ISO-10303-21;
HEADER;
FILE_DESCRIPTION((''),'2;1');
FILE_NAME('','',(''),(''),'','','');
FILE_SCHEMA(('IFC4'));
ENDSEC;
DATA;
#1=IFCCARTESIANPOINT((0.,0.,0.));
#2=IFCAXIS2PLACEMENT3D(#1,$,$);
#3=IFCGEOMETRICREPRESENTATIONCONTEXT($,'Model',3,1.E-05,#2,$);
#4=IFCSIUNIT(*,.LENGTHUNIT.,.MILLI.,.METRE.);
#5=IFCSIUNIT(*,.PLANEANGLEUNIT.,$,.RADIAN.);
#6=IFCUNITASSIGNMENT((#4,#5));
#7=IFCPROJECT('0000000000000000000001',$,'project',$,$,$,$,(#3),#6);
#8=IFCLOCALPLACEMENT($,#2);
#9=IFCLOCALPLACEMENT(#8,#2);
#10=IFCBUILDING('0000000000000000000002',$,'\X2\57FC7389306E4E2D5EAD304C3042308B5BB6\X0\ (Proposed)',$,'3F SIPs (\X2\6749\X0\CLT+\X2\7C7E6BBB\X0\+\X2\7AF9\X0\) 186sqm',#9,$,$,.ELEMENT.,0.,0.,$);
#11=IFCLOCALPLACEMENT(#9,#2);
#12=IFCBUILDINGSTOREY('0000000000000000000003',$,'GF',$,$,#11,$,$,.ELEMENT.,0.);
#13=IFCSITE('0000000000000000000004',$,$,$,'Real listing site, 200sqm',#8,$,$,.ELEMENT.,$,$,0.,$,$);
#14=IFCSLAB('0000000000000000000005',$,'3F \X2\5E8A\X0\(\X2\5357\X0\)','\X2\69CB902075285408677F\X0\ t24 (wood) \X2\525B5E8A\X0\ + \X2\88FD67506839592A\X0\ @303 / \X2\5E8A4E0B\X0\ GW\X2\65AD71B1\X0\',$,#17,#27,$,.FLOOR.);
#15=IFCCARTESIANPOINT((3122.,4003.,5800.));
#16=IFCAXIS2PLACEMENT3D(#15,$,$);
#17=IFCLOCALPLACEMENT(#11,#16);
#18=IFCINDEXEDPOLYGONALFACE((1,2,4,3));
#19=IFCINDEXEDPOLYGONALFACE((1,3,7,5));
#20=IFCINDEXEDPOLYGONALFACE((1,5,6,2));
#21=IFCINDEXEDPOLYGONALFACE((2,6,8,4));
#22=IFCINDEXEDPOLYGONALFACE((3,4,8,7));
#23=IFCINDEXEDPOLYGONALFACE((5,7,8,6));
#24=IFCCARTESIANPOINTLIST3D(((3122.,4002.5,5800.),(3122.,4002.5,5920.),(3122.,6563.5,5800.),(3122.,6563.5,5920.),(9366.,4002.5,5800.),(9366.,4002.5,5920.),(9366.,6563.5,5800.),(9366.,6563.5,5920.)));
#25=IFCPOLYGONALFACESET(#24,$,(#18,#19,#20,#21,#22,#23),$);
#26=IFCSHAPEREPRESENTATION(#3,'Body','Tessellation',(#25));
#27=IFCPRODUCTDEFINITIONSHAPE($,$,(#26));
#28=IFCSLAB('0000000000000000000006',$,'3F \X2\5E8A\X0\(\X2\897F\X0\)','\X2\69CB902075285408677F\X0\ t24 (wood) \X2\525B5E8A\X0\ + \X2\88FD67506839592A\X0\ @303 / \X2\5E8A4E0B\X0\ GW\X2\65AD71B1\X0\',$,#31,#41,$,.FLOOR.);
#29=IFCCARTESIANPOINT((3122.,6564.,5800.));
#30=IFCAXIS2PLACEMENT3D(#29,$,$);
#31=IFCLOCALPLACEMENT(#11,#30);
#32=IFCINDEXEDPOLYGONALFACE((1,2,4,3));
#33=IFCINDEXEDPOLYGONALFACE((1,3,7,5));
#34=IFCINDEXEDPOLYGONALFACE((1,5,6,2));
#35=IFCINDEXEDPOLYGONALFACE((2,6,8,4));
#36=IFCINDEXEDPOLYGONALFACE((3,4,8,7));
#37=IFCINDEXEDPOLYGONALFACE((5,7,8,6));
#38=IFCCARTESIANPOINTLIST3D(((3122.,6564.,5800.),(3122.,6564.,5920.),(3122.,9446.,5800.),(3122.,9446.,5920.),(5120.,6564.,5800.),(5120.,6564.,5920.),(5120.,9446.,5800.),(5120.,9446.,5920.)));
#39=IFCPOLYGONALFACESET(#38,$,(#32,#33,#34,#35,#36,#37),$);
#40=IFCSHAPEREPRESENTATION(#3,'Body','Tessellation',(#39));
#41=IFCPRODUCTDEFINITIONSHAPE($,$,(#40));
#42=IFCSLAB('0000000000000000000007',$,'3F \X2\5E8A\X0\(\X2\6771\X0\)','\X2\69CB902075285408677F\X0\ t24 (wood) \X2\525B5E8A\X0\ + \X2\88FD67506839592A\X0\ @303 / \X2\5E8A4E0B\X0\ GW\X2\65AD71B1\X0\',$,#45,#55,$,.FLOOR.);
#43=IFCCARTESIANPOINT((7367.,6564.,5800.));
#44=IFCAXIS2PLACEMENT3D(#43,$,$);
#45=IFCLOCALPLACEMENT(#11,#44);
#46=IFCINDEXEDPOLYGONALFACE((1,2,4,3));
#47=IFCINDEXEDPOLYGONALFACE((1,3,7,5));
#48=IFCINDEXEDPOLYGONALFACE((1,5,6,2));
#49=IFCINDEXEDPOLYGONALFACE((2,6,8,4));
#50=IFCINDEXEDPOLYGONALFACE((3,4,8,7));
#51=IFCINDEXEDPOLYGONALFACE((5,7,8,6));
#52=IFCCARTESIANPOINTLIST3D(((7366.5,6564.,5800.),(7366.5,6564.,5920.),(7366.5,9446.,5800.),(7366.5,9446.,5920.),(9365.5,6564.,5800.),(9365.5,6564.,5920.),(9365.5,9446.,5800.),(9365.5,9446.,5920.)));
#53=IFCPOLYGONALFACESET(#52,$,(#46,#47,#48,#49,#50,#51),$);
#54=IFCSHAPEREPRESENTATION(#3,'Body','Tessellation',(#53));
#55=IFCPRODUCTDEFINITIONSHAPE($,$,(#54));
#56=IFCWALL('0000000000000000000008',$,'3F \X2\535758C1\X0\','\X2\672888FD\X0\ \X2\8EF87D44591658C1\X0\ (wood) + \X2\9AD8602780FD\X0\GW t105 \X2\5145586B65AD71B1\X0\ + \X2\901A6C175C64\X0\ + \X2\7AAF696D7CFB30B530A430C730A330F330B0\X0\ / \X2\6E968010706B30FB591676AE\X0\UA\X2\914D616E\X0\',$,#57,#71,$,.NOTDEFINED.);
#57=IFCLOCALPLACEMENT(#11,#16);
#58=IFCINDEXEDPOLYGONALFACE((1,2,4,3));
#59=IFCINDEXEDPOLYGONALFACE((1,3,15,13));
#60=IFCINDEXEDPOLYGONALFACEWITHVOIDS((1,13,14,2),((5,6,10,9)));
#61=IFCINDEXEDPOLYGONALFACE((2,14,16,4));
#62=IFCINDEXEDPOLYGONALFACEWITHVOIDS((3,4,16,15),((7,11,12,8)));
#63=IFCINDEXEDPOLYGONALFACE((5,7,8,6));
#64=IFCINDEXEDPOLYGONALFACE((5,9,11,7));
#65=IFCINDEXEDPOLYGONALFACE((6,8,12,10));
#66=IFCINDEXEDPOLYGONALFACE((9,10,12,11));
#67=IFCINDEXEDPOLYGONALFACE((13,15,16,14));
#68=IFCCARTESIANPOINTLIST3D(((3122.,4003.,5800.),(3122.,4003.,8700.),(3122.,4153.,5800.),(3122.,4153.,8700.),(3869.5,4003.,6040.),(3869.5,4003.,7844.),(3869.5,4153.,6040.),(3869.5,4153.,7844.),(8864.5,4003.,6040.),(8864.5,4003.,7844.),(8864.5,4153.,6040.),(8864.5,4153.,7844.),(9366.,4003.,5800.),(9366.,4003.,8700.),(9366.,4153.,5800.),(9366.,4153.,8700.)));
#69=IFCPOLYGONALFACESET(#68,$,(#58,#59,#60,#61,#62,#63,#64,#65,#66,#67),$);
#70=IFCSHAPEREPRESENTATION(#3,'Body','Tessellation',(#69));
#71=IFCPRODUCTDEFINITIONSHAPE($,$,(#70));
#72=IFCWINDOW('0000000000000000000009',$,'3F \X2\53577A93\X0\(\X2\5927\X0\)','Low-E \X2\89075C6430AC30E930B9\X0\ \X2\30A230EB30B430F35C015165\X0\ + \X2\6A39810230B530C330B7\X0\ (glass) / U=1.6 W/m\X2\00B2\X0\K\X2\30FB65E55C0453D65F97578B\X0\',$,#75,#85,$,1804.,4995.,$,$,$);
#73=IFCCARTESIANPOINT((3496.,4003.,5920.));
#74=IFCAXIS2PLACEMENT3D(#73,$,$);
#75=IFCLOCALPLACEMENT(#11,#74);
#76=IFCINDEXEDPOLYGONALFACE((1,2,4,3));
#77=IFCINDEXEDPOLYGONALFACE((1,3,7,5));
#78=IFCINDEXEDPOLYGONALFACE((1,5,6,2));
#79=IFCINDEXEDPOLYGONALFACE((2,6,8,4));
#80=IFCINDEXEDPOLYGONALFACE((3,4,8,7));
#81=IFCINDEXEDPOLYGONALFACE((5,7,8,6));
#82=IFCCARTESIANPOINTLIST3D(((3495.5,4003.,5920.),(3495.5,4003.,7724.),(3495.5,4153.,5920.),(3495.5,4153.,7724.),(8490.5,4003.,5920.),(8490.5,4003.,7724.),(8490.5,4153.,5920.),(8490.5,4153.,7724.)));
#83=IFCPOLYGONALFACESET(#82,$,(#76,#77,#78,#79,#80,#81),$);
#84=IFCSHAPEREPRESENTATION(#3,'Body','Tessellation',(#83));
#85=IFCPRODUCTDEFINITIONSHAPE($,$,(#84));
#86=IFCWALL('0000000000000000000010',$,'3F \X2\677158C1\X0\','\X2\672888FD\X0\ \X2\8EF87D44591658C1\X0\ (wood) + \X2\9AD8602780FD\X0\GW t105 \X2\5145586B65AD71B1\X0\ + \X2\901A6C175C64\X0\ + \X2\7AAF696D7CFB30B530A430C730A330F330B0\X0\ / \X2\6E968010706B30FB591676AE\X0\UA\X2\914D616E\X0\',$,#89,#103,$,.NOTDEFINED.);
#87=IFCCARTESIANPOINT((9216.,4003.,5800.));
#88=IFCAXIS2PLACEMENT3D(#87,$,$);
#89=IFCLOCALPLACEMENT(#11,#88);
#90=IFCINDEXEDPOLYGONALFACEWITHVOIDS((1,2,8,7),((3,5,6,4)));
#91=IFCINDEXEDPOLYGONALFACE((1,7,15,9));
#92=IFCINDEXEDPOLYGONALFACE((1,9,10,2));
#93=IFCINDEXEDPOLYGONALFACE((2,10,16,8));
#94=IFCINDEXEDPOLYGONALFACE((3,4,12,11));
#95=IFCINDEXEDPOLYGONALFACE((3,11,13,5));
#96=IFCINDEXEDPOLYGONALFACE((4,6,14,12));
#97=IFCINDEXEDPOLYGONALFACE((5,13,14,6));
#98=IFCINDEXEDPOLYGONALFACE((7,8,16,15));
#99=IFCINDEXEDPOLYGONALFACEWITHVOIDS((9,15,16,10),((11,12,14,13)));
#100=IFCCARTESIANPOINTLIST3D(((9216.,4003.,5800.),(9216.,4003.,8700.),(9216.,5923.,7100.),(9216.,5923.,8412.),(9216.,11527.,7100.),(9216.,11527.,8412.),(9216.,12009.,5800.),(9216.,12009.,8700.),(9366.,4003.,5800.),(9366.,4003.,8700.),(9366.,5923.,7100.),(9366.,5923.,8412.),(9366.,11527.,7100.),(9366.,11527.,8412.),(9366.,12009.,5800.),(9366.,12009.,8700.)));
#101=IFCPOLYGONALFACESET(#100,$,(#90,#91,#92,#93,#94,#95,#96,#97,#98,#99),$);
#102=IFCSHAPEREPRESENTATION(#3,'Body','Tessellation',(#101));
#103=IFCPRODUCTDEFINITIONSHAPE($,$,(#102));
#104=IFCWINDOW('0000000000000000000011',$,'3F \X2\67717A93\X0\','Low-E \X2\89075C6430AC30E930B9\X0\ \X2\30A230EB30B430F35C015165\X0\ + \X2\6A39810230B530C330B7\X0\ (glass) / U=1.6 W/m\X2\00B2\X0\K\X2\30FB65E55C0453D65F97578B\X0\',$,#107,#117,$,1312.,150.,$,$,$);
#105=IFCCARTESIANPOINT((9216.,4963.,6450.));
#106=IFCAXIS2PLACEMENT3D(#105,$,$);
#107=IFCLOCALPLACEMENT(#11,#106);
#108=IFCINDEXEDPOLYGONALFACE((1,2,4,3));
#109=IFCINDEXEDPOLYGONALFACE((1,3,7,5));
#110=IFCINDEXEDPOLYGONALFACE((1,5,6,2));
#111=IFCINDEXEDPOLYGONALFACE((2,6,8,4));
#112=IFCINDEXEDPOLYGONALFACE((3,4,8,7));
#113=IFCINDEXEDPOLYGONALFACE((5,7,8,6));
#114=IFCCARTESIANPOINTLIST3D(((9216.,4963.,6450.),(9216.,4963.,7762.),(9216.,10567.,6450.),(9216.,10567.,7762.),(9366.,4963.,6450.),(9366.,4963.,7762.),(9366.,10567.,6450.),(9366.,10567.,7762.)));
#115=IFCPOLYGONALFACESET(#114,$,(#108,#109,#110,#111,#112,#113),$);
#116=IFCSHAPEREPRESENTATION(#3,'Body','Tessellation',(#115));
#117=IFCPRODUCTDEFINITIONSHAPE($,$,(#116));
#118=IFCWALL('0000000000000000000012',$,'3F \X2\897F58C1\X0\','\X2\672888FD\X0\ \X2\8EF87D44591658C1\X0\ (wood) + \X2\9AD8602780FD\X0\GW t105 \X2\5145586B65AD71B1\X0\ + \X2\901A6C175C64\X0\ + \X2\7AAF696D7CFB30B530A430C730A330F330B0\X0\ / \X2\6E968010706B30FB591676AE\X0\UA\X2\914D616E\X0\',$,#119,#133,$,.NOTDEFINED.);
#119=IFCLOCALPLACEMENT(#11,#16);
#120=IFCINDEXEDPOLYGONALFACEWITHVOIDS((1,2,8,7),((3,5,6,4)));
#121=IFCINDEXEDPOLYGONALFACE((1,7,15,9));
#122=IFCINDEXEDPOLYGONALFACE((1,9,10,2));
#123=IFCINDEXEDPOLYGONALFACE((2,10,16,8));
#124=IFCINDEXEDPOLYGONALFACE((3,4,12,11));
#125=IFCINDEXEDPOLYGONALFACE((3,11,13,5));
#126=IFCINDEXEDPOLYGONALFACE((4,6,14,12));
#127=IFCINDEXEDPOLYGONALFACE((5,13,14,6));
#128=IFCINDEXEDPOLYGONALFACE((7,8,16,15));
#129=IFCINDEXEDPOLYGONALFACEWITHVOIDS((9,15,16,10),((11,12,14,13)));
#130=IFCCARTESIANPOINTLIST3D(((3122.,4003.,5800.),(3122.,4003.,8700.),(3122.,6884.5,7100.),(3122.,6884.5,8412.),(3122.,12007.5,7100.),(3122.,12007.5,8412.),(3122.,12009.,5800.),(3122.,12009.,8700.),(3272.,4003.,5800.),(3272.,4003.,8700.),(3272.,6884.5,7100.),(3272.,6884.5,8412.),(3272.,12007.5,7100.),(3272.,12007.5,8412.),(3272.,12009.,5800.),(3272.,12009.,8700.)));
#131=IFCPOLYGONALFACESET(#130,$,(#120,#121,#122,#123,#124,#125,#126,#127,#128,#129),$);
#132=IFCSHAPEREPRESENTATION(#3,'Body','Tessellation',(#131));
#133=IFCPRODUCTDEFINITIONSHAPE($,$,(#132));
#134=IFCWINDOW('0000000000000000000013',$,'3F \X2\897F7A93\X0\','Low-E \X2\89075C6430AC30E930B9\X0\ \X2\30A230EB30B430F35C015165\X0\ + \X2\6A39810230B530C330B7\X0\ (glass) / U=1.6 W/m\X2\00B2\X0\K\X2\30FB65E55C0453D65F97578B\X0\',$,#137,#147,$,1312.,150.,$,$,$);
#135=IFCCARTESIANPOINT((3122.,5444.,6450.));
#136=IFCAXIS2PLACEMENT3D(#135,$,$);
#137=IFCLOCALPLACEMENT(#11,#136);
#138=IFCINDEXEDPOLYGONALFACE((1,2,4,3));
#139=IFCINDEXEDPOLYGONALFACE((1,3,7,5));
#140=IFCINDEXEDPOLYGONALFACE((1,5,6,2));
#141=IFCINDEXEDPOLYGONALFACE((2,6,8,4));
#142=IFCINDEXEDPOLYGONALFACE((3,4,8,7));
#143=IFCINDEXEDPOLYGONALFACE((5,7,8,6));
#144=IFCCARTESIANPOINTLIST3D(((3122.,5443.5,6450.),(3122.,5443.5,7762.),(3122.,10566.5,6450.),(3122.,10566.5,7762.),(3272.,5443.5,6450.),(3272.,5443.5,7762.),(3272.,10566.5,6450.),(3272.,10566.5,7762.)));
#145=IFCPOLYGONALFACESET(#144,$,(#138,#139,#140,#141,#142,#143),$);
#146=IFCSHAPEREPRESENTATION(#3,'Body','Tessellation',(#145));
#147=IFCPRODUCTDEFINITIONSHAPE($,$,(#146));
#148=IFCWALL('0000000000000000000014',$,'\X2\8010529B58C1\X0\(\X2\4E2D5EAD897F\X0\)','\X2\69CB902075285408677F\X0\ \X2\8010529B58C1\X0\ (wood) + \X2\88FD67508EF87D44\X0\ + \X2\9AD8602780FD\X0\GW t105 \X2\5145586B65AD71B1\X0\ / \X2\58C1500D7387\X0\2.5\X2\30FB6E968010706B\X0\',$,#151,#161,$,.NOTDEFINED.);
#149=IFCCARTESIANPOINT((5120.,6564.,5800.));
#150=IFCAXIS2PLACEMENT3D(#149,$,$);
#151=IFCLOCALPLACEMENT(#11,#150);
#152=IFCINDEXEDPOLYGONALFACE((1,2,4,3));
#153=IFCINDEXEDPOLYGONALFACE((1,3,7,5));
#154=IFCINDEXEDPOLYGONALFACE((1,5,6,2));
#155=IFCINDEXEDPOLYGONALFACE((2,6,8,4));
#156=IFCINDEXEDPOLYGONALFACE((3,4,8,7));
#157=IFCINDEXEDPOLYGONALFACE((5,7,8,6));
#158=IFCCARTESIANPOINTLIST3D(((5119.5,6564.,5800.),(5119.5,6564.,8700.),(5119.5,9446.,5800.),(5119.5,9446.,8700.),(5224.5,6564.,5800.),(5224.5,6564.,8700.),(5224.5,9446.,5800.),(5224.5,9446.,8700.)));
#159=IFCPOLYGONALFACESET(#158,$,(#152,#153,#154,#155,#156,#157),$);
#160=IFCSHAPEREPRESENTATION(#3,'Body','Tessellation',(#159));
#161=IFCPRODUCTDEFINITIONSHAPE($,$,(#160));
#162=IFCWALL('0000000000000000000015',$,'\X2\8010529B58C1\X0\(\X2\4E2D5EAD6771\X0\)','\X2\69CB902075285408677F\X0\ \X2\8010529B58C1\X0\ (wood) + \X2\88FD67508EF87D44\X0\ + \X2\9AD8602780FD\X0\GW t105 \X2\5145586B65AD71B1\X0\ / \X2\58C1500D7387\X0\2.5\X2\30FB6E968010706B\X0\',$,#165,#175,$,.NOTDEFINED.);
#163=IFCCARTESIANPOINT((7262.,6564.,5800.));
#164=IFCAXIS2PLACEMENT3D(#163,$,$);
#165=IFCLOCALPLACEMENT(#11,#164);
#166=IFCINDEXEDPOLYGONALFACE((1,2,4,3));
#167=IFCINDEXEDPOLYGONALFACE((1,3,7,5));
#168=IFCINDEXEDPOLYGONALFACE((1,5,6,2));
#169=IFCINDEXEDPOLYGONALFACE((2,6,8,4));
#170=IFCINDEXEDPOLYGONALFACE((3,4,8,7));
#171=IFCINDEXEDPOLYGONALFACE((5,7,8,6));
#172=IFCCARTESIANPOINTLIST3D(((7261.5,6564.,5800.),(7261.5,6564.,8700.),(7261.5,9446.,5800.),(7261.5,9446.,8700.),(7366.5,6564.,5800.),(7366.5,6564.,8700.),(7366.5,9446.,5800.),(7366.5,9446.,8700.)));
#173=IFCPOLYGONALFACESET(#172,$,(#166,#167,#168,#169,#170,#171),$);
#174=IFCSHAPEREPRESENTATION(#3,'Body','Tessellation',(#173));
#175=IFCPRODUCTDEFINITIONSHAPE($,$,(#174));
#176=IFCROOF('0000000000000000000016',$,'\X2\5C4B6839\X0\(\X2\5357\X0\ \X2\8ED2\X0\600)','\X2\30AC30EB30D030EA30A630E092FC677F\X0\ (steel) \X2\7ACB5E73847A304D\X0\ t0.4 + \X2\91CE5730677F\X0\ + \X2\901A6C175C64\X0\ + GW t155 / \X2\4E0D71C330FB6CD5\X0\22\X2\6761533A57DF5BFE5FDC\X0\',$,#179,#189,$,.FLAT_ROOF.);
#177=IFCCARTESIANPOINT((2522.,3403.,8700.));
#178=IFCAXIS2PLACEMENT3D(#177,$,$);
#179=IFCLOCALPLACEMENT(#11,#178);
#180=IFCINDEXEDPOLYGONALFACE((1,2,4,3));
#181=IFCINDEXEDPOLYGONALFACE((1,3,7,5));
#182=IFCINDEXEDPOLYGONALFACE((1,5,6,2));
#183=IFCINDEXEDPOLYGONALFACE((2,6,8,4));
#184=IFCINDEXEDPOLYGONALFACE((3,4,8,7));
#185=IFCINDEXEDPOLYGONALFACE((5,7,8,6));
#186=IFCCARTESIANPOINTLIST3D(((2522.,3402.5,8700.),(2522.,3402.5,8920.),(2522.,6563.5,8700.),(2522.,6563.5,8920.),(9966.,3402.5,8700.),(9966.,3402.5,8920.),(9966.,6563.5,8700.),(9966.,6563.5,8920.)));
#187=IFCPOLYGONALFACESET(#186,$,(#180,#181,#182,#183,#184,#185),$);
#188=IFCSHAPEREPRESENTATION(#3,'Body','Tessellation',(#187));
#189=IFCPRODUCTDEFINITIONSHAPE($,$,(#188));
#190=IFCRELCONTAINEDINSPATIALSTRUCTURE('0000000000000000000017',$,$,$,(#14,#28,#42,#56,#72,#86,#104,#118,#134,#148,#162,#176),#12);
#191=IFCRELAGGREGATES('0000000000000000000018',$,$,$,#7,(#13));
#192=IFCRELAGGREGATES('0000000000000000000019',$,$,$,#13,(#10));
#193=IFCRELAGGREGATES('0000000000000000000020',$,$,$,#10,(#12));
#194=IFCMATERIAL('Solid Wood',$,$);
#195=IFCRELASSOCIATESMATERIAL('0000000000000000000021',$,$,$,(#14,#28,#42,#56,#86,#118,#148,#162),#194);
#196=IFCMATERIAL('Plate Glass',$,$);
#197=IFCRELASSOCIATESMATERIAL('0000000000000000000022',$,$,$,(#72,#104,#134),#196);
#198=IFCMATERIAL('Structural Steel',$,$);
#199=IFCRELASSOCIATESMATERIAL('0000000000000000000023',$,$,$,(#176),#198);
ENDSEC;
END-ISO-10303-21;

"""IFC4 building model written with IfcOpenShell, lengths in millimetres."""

from ifc_helpers import new_model, si_unit, frame, frame_2d, origin, place, context, project, spatial, rectangle, extrude, material, element, fill, save


model = new_model("IFC4")

# Units and contexts
model_context = context("Model", 3, precision=1e-05, world=origin())
ifc_project = project(units=[si_unit("LENGTHUNIT", "METRE", prefix="MILLI"), si_unit("PLANEANGLEUNIT", "RADIAN")], contexts=[model_context])

# Site, building, storey
site_placement = place(None, origin())
site = spatial("IfcSite", under=ifc_project, at=site_placement, ObjectType="Real listing site, 200sqm", CompositionType="ELEMENT", RefElevation=0.0)
building_placement = place(site_placement, origin())
building = spatial("IfcBuilding", under=site, at=building_placement, Name="埼玉の中庭がある家 (Proposed)", ObjectType="3F SIPs (杉CLT+籾殻+竹) 186sqm", CompositionType="ELEMENT", ElevationOfRefHeight=0.0, ElevationOfTerrain=0.0)
storey_placement = place(building_placement, origin())
storey = spatial("IfcBuildingStorey", under=building, at=storey_placement, Name="GF", CompositionType="ELEMENT", Elevation=0.0)

# Slabs
ifc_material_1 = material(Name="Solid Wood")
slab_1_placement = place(storey_placement, frame((3122.0, 4003.0, 5800.0)))
element("IfcSlab", 1, at=slab_1_placement, inside=storey, material=ifc_material_1, Name="3F 床(南)", Description="構造用合板 t24 (wood) 剛床 + 製材根太 @303 / 床下 GW断熱", PredefinedType="FLOOR", context=model_context, shape_type="SweptSolid", body=[
    extrude(rectangle(XDim=6244.0, YDim=2561.0, at=frame_2d((3122.0, 1280.0))), frame((3122.0, 4003.0, 5800.0)), (0.0, 0.0, 1.0), 120.0),
])
slab_2_placement = place(storey_placement, frame((3122.0, 6564.0, 5800.0)))
element("IfcSlab", 2, at=slab_2_placement, inside=storey, material=ifc_material_1, Name="3F 床(西)", Description="構造用合板 t24 (wood) 剛床 + 製材根太 @303 / 床下 GW断熱", PredefinedType="FLOOR", context=model_context, shape_type="SweptSolid", body=[
    extrude(rectangle(XDim=1998.0, YDim=2882.0, at=frame_2d((999.0, 1441.0))), frame((3122.0, 6564.0, 5800.0)), (0.0, 0.0, 1.0), 120.0),
])
slab_3_placement = place(storey_placement, frame((7367.0, 6564.0, 5800.0)))
element("IfcSlab", 3, at=slab_3_placement, inside=storey, material=ifc_material_1, Name="3F 床(東)", Description="構造用合板 t24 (wood) 剛床 + 製材根太 @303 / 床下 GW断熱", PredefinedType="FLOOR", context=model_context, shape_type="SweptSolid", body=[
    extrude(rectangle(XDim=1999.0, YDim=2882.0, at=frame_2d((999.0, 1441.0))), frame((7367.0, 6564.0, 5800.0)), (0.0, 0.0, 1.0), 120.0),
])

# Walls, openings, windows
wall_1_placement = place(storey_placement, frame((3122.0, 4003.0, 5800.0)))
wall_1 = element("IfcWall", 4, at=wall_1_placement, inside=storey, material=ifc_material_1, Name="3F 南壁", Description="木製 軸組外壁 (wood) + 高性能GW t105 充填断熱 + 通気層 + 窯業系サイディング / 準耐火・外皮UA配慮", PredefinedType="NOTDEFINED", context=model_context, shape_type="SweptSolid", body=[
    extrude(rectangle(XDim=6244.0, YDim=150.0, at=frame_2d((3122.0, 75.0))), frame((3122.0, 4003.0, 5800.0)), (0.0, 0.0, 1.0), 2900.0),
])
opening_1_placement = place(storey_placement, frame((3496.0, 4003.0, 5920.0)))
opening_1 = element("IfcOpeningElement", 5, at=opening_1_placement, cuts=wall_1, PredefinedType="NOTDEFINED", context=model_context, shape_type="SweptSolid", body=[
    extrude(rectangle(XDim=4995.0, YDim=150.0, at=frame_2d((2497.0, 75.0))), frame((3496.0, 4003.0, 5920.0)), (0.0, 0.0, 1.0), 1804.0),
])
ifc_material_2 = material(Name="Plate Glass")
window_1_placement = place(storey_placement, frame((3496.0, 4003.0, 5920.0)))
window_1 = element("IfcWindow", 6, at=window_1_placement, inside=storey, material=ifc_material_2, Name="3F 南窓(大)", Description="Low-E 複層ガラス アルゴン封入 + 樹脂サッシ (glass) / U=1.6 W/m²K・日射取得型", OverallHeight=1804.0, OverallWidth=4995.0, context=model_context, shape_type="SweptSolid", body=[
    extrude(rectangle(XDim=4995.0, YDim=150.0, at=frame_2d((2497.0, 75.0))), frame((3496.0, 4003.0, 5920.0)), (0.0, 0.0, 1.0), 1804.0),
])
fill(opening_1, window_1)
wall_2_placement = place(storey_placement, frame((9216.0, 4003.0, 5800.0)))
wall_2 = element("IfcWall", 7, at=wall_2_placement, inside=storey, material=ifc_material_1, Name="3F 東壁", Description="木製 軸組外壁 (wood) + 高性能GW t105 充填断熱 + 通気層 + 窯業系サイディング / 準耐火・外皮UA配慮", PredefinedType="NOTDEFINED", context=model_context, shape_type="SweptSolid", body=[
    extrude(rectangle(XDim=150.0, YDim=8006.0, at=frame_2d((75.0, 4003.0))), frame((9216.0, 4003.0, 5800.0)), (0.0, 0.0, 1.0), 2900.0),
])
opening_2_placement = place(storey_placement, frame((9216.0, 4963.0, 6450.0)))
opening_2 = element("IfcOpeningElement", 8, at=opening_2_placement, cuts=wall_2, PredefinedType="NOTDEFINED", context=model_context, shape_type="SweptSolid", body=[
    extrude(rectangle(XDim=150.0, YDim=5604.0, at=frame_2d((75.0, 2802.0))), frame((9216.0, 4963.0, 6450.0)), (0.0, 0.0, 1.0), 1312.0),
])
window_2_placement = place(storey_placement, frame((9216.0, 4963.0, 6450.0)))
window_2 = element("IfcWindow", 9, at=window_2_placement, inside=storey, material=ifc_material_2, Name="3F 東窓", Description="Low-E 複層ガラス アルゴン封入 + 樹脂サッシ (glass) / U=1.6 W/m²K・日射取得型", OverallHeight=1312.0, OverallWidth=150.0, context=model_context, shape_type="SweptSolid", body=[
    extrude(rectangle(XDim=150.0, YDim=5604.0, at=frame_2d((75.0, 2802.0))), frame((9216.0, 4963.0, 6450.0)), (0.0, 0.0, 1.0), 1312.0),
])
fill(opening_2, window_2)
wall_3_placement = place(storey_placement, frame((3122.0, 4003.0, 5800.0)))
wall_3 = element("IfcWall", 10, at=wall_3_placement, inside=storey, material=ifc_material_1, Name="3F 西壁", Description="木製 軸組外壁 (wood) + 高性能GW t105 充填断熱 + 通気層 + 窯業系サイディング / 準耐火・外皮UA配慮", PredefinedType="NOTDEFINED", context=model_context, shape_type="SweptSolid", body=[
    extrude(rectangle(XDim=150.0, YDim=8006.0, at=frame_2d((75.0, 4003.0))), frame((3122.0, 4003.0, 5800.0)), (0.0, 0.0, 1.0), 2900.0),
])
opening_3_placement = place(storey_placement, frame((3122.0, 5444.0, 6450.0)))
opening_3 = element("IfcOpeningElement", 11, at=opening_3_placement, cuts=wall_3, PredefinedType="NOTDEFINED", context=model_context, shape_type="SweptSolid", body=[
    extrude(rectangle(XDim=150.0, YDim=5123.0, at=frame_2d((75.0, 2561.0))), frame((3122.0, 5444.0, 6450.0)), (0.0, 0.0, 1.0), 1312.0),
])
window_3_placement = place(storey_placement, frame((3122.0, 5444.0, 6450.0)))
window_3 = element("IfcWindow", 12, at=window_3_placement, inside=storey, material=ifc_material_2, Name="3F 西窓", Description="Low-E 複層ガラス アルゴン封入 + 樹脂サッシ (glass) / U=1.6 W/m²K・日射取得型", OverallHeight=1312.0, OverallWidth=150.0, context=model_context, shape_type="SweptSolid", body=[
    extrude(rectangle(XDim=150.0, YDim=5123.0, at=frame_2d((75.0, 2561.0))), frame((3122.0, 5444.0, 6450.0)), (0.0, 0.0, 1.0), 1312.0),
])
fill(opening_3, window_3)

# Walls
wall_4_placement = place(storey_placement, frame((5120.0, 6564.0, 5800.0)))
element("IfcWall", 13, at=wall_4_placement, inside=storey, material=ifc_material_1, Name="耐力壁(中庭西)", Description="構造用合板 耐力壁 (wood) + 製材軸組 + 高性能GW t105 充填断熱 / 壁倍率2.5・準耐火", PredefinedType="NOTDEFINED", context=model_context, shape_type="SweptSolid", body=[
    extrude(rectangle(XDim=105.0, YDim=2882.0, at=frame_2d((52.0, 1441.0))), frame((5120.0, 6564.0, 5800.0)), (0.0, 0.0, 1.0), 2900.0),
])
wall_5_placement = place(storey_placement, frame((7262.0, 6564.0, 5800.0)))
element("IfcWall", 14, at=wall_5_placement, inside=storey, material=ifc_material_1, Name="耐力壁(中庭東)", Description="構造用合板 耐力壁 (wood) + 製材軸組 + 高性能GW t105 充填断熱 / 壁倍率2.5・準耐火", PredefinedType="NOTDEFINED", context=model_context, shape_type="SweptSolid", body=[
    extrude(rectangle(XDim=105.0, YDim=2882.0, at=frame_2d((52.0, 1441.0))), frame((7262.0, 6564.0, 5800.0)), (0.0, 0.0, 1.0), 2900.0),
])

# Roof
ifc_material_3 = material(Name="Structural Steel")
roof_1_placement = place(storey_placement, frame((2522.0, 3403.0, 8700.0)))
element("IfcRoof", 15, at=roof_1_placement, inside=storey, material=ifc_material_3, Name="屋根(南 軒600)", Description="ガルバリウム鋼板 (steel) 立平葺き t0.4 + 野地板 + 通気層 + GW t155 / 不燃・法22条区域対応", PredefinedType="FLAT_ROOF", context=model_context, shape_type="SweptSolid", body=[
    extrude(rectangle(XDim=7444.0, YDim=3161.0, at=frame_2d((3722.0, 1580.0))), frame((2522.0, 3403.0, 8700.0)), (0.0, 0.0, 1.0), 220.0),
])

save(model, "model.ifc")
